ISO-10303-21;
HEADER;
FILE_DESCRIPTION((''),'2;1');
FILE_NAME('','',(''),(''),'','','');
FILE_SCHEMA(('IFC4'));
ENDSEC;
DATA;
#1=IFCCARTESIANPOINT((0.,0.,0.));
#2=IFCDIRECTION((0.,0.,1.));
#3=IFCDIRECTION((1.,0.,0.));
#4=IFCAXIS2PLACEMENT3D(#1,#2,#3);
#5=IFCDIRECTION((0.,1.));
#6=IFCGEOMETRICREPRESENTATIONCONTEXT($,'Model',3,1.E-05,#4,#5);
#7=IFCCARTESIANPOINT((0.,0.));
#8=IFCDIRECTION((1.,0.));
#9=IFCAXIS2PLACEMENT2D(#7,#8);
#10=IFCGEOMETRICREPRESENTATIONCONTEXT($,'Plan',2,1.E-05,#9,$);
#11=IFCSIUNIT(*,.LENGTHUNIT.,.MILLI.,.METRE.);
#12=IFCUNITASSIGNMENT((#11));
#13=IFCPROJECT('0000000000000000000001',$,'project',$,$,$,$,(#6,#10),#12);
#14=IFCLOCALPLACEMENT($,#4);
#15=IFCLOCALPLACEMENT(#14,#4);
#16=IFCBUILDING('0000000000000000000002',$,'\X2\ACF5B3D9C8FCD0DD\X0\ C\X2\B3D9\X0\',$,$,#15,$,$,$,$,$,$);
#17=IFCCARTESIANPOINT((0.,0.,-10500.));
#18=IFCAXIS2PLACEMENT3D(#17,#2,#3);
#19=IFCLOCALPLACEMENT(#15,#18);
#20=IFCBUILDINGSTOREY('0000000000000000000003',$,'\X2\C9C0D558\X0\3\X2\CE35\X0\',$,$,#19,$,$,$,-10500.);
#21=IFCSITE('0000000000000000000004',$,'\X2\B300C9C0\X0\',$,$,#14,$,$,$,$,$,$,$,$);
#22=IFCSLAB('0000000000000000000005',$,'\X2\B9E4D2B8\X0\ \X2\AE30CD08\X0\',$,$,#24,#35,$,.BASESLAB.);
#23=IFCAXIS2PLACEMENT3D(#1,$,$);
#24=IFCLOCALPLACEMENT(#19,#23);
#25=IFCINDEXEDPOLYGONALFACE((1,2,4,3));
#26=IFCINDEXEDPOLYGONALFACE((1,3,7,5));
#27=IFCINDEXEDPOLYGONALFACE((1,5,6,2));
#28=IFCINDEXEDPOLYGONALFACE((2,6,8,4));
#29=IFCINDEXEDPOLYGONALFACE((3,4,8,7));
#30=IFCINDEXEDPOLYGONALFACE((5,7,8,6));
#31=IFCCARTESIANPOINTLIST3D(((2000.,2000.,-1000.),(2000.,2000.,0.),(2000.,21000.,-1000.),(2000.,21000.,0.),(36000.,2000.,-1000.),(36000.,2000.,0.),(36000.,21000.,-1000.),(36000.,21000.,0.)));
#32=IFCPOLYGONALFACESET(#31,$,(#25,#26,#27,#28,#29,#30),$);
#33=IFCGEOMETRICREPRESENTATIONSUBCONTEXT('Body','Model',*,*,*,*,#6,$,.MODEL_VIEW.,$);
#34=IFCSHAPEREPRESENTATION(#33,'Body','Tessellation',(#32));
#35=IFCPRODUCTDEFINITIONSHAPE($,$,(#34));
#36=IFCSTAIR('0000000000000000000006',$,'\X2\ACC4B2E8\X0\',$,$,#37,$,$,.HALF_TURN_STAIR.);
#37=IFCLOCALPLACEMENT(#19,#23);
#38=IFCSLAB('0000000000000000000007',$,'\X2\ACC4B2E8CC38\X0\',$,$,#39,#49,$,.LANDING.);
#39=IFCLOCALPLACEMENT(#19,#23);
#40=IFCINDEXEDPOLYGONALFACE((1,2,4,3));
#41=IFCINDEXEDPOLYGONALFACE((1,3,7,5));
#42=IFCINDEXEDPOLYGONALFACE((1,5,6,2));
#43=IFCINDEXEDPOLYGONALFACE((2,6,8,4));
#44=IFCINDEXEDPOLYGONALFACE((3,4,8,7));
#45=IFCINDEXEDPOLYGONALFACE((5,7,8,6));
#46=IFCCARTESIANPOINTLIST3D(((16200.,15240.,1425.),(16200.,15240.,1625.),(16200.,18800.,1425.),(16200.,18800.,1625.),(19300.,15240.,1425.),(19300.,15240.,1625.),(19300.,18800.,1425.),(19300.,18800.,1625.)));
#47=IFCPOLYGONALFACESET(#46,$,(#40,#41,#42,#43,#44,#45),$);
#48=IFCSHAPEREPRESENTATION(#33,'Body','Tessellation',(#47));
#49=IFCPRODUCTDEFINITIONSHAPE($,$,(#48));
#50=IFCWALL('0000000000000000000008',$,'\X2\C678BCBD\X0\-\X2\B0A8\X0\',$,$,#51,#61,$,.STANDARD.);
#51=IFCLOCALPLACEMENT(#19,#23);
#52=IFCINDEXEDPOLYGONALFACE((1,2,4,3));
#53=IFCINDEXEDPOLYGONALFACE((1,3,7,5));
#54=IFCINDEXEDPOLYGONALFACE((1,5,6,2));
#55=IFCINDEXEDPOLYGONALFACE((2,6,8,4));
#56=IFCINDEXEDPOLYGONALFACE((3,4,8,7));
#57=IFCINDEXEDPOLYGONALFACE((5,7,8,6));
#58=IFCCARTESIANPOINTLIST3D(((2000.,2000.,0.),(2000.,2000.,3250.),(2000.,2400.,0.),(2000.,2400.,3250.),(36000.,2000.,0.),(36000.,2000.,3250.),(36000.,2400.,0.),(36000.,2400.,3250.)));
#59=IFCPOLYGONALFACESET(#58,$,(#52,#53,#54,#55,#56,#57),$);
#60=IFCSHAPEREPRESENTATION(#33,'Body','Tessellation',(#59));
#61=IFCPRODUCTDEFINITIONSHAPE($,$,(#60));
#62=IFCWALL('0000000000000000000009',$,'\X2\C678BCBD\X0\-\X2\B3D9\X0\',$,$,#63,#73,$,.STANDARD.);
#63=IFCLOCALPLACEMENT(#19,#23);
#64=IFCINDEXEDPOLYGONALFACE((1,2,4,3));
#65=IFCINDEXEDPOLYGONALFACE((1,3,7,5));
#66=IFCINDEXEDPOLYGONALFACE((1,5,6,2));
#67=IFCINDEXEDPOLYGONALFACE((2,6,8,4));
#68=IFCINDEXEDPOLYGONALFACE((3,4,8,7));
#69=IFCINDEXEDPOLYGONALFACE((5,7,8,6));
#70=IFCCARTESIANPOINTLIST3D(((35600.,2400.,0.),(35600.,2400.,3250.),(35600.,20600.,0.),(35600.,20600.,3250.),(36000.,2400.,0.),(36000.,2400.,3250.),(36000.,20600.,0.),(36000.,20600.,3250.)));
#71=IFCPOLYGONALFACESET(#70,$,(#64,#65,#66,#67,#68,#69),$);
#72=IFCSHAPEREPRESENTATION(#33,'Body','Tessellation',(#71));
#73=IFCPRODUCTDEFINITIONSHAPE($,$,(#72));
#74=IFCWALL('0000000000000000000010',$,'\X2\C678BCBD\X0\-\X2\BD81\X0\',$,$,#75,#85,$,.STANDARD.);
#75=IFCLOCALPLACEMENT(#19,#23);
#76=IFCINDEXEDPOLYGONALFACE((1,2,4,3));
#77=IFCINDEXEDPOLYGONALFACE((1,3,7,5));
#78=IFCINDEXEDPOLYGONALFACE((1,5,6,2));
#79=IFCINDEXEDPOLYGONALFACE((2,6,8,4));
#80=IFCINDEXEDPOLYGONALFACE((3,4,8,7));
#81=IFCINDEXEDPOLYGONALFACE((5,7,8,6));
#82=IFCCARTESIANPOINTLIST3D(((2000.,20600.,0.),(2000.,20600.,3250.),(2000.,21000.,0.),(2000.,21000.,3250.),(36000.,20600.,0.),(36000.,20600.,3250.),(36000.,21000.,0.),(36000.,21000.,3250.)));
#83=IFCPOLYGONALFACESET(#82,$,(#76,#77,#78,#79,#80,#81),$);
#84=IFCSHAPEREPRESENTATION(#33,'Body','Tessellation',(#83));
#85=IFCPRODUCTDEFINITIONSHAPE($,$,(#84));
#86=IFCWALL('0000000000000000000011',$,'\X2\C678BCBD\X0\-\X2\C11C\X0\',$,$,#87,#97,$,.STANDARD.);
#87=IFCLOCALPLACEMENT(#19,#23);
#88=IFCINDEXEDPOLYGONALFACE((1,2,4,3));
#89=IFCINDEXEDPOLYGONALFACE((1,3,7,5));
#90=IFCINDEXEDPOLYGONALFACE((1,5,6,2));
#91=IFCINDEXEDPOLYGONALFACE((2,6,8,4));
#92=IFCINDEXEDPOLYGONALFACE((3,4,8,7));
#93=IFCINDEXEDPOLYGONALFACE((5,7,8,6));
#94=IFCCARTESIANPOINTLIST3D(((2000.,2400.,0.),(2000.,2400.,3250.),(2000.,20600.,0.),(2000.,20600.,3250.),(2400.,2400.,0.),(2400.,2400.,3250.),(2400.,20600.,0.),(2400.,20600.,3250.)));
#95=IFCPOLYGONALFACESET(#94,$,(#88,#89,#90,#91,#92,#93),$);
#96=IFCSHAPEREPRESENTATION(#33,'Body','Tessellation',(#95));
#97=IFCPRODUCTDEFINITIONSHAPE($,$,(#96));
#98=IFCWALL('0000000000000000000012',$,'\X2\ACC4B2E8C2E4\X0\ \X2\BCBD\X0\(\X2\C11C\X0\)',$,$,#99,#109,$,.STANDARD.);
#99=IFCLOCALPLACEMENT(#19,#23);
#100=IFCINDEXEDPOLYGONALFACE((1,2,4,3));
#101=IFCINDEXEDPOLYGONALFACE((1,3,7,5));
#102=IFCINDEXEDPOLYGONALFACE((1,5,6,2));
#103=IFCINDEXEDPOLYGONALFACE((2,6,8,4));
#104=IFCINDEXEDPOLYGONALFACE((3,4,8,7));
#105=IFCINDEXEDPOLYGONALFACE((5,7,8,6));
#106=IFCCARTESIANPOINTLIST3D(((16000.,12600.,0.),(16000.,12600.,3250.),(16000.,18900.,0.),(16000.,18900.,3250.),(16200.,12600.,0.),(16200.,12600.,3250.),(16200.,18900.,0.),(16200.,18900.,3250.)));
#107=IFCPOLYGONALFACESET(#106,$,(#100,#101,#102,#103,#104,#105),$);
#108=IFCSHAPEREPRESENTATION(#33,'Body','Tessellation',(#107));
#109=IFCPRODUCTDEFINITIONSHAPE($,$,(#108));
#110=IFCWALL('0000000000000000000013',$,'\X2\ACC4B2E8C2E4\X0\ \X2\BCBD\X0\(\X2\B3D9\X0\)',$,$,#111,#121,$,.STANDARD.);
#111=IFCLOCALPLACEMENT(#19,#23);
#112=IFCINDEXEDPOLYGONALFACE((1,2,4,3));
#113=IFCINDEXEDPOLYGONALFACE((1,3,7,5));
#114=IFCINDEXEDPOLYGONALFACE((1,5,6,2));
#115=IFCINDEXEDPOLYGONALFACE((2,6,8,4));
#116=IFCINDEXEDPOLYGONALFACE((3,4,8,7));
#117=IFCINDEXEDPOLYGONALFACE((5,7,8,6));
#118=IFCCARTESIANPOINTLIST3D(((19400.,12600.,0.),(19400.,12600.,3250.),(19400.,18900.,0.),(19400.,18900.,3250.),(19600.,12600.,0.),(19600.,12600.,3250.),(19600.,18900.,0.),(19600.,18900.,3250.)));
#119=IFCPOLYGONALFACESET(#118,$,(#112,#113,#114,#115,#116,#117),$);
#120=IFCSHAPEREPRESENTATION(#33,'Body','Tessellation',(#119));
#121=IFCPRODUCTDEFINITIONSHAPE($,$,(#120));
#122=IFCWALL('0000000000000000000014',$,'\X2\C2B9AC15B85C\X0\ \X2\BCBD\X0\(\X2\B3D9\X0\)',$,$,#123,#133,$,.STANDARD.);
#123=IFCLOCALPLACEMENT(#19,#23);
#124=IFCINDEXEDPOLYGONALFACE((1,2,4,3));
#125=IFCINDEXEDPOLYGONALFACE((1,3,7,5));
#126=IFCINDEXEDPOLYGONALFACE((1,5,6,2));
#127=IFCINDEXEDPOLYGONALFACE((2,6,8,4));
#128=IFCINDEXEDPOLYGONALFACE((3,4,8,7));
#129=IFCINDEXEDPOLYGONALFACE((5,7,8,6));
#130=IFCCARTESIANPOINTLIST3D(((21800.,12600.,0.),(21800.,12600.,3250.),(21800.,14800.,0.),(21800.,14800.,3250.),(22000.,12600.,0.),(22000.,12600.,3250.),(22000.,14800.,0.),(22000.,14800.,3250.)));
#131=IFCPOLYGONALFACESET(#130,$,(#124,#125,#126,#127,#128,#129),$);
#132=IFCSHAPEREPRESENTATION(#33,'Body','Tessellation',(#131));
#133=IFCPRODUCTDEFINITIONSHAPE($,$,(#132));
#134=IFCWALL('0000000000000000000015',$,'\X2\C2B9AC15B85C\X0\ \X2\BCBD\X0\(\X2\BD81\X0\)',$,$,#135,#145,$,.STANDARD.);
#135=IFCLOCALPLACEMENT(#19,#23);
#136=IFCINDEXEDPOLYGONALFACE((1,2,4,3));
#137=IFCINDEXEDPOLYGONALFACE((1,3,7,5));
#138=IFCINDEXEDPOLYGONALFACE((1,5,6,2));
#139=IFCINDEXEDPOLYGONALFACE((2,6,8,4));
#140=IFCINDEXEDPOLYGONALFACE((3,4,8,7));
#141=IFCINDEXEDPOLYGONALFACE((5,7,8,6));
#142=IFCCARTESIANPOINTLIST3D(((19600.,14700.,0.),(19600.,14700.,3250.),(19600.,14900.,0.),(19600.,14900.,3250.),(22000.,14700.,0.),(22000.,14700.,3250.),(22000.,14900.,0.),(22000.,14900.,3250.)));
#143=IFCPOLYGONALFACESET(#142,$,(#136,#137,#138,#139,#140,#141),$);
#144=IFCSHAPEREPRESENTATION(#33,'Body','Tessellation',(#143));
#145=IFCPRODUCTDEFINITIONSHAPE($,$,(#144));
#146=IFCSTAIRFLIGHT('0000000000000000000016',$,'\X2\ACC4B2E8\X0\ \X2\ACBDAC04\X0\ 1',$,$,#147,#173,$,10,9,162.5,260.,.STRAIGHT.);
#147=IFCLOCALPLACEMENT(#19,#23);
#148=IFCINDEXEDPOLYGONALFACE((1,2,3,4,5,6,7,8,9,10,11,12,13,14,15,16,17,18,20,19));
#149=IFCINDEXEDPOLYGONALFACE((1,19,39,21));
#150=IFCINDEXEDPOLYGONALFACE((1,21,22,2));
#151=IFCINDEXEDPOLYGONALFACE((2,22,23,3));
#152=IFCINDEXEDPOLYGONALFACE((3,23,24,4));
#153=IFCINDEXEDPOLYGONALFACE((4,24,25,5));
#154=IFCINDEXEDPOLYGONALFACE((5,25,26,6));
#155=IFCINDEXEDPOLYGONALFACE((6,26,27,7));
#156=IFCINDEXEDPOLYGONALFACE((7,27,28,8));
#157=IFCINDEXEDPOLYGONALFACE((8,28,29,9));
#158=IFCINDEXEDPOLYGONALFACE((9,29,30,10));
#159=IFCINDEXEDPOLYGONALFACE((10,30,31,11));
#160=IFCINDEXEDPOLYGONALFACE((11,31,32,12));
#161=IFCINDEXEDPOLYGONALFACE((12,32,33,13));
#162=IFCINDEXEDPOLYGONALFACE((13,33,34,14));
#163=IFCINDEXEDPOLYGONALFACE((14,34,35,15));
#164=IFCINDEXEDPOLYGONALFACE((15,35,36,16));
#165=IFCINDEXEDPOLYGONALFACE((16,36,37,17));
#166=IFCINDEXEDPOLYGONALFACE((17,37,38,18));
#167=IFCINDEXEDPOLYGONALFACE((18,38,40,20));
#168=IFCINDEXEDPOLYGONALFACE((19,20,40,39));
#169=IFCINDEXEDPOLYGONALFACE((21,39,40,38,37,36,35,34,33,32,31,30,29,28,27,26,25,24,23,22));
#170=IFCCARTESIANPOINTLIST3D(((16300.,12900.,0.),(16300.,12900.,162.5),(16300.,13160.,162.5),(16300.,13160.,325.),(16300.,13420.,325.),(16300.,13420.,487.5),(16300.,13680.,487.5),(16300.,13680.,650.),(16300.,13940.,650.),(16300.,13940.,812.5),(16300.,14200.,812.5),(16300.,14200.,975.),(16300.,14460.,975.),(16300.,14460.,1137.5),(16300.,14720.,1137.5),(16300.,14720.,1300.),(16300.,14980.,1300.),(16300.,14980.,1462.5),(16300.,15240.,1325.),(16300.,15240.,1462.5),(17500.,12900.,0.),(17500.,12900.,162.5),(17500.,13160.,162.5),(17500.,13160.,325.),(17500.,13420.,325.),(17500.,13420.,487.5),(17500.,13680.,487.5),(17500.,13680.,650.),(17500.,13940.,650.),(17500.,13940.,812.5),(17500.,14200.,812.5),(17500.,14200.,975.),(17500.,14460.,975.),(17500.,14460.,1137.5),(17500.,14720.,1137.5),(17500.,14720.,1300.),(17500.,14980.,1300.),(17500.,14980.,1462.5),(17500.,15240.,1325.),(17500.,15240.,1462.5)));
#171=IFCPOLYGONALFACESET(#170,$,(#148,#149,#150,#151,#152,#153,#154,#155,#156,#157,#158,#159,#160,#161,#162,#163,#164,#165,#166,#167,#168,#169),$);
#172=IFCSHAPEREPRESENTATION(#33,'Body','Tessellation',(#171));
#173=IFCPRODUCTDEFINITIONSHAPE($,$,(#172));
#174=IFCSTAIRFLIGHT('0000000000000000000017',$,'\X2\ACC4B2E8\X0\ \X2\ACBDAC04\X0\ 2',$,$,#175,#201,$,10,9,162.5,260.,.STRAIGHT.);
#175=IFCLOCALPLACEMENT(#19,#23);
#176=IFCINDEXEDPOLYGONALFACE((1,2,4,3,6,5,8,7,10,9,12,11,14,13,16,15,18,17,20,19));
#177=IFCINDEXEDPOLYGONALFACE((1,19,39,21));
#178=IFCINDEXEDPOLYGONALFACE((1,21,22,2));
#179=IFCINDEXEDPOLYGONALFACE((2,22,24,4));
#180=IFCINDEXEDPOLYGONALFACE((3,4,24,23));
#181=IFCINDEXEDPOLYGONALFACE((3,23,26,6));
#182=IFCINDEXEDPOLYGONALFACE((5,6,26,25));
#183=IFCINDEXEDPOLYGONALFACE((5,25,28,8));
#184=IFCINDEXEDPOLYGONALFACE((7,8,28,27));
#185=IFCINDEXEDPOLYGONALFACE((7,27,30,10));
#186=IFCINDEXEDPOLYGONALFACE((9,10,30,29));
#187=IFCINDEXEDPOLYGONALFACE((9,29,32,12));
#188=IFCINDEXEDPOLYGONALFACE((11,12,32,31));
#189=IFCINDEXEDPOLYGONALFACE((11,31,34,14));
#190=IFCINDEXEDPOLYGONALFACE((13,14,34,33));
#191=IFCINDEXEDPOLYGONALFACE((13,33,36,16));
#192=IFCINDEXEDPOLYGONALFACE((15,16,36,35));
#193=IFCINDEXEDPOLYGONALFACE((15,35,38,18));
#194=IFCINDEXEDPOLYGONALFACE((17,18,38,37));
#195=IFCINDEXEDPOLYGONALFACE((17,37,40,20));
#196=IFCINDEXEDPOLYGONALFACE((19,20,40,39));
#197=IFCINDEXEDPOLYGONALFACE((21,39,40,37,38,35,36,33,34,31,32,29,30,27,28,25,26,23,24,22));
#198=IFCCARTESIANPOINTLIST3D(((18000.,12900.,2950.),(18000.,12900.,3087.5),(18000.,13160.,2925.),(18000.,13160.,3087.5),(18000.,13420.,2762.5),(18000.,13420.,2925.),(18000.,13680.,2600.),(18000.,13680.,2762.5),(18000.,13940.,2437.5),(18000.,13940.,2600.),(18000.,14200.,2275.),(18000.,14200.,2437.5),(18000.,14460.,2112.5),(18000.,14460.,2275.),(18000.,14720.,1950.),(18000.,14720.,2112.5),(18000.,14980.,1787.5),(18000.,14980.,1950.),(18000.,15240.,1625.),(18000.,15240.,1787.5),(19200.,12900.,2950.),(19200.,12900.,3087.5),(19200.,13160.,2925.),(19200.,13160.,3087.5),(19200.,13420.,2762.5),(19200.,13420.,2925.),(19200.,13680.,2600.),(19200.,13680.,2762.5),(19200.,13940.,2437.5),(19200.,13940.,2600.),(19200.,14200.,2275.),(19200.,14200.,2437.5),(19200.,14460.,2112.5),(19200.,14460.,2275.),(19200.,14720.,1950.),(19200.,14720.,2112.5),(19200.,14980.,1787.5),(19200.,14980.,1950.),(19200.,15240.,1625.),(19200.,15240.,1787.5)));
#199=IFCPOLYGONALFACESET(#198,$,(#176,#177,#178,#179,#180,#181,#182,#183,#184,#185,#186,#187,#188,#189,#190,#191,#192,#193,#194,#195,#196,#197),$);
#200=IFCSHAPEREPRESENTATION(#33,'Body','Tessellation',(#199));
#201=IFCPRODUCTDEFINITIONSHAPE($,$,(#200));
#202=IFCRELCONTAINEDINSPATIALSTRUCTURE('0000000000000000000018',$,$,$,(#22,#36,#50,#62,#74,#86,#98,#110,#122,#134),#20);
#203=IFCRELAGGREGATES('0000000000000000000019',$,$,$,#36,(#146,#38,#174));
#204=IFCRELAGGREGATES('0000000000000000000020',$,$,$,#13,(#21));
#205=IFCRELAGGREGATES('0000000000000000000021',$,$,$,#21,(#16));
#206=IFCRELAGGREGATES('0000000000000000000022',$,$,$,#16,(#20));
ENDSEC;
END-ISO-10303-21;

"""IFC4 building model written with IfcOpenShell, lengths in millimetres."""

from ifc_helpers import new_model, si_unit, direction, frame, origin_with_axes, origin_2d_with_axis, place, context, subcontext, project, spatial, polyline, outline, extrude, element, aggregate, save


model = new_model("IFC4")

# Units and contexts
model_context = context("Model", 3, precision=1e-05, world=origin_with_axes(), true_north=direction((0.0, 1.0)))
plan_context = context("Plan", 2, precision=1e-05, world=origin_2d_with_axis())
body_context = subcontext(model_context, "Body", "Model", "MODEL_VIEW")
ifc_project = project(units=[si_unit("LENGTHUNIT", "METRE", prefix="MILLI")], contexts=[model_context, plan_context])

# Site, building, storey
site_placement = place(None, origin_with_axes())
site = spatial("IfcSite", under=ifc_project, at=site_placement, Name="대지")
building_placement = place(site_placement, origin_with_axes())
building = spatial("IfcBuilding", under=site, at=building_placement, Name="공동주택 C동")
storey_placement = place(building_placement, frame((0.0, 0.0, -10500.0), z_axis=(0.0, 0.0, 1.0), x_axis=(1.0, 0.0, 0.0)))
storey = spatial("IfcBuildingStorey", under=building, at=storey_placement, Name="지하3층", Elevation=-10500.0)

# Slab
slab_1_placement = place(storey_placement, origin_with_axes())
element("IfcSlab", 1, at=slab_1_placement, inside=storey, Name="매트 기초", PredefinedType="BASESLAB", context=body_context, shape_type="SweptSolid", body=[
    extrude(outline(polyline([(2000.0, 2000.0), (36000.0, 2000.0), (36000.0, 21000.0), (2000.0, 21000.0), (2000.0, 2000.0)])), frame((0.0, 0.0, -1000.0), z_axis=(0.0, 0.0, 1.0), x_axis=(1.0, 0.0, 0.0)), (0.0, 0.0, 1.0), 1000.0),
])

# Stair, slab
stair_placement = place(storey_placement, origin_with_axes())
stair = element("IfcStair", 2, at=stair_placement, inside=storey, Name="계단", PredefinedType="HALF_TURN_STAIR")
slab_2_placement = place(stair_placement, origin_with_axes())
slab_2 = element("IfcSlab", 3, at=slab_2_placement, Name="계단참", PredefinedType="LANDING", context=body_context, shape_type="SweptSolid", body=[
    extrude(outline(polyline([(16200.0, 15240.0), (19300.0, 15240.0), (19300.0, 18800.0), (16200.0, 18800.0), (16200.0, 15240.0)])), frame((0.0, 0.0, 1425.0), z_axis=(0.0, 0.0, 1.0), x_axis=(1.0, 0.0, 0.0)), (0.0, 0.0, 1.0), 200.0),
])

# Walls
wall_1_placement = place(storey_placement, origin_with_axes())
element("IfcWall", 4, at=wall_1_placement, inside=storey, Name="외벽-남", PredefinedType="STANDARD", context=body_context, shape_type="SweptSolid", body=[
    extrude(outline(polyline([(2000.0, 2400.0), (36000.0, 2400.0), (36000.0, 2000.0), (2000.0, 2000.0), (2000.0, 2400.0)])), origin_with_axes(), (0.0, 0.0, 1.0), 3250.0),
])
wall_2_placement = place(storey_placement, origin_with_axes())
element("IfcWall", 5, at=wall_2_placement, inside=storey, Name="외벽-동", PredefinedType="STANDARD", context=body_context, shape_type="SweptSolid", body=[
    extrude(outline(polyline([(35600.0, 2400.0), (35600.0, 20600.0), (36000.0, 20600.0), (36000.0, 2400.0), (35600.0, 2400.0)])), origin_with_axes(), (0.0, 0.0, 1.0), 3250.0),
])
wall_3_placement = place(storey_placement, origin_with_axes())
element("IfcWall", 6, at=wall_3_placement, inside=storey, Name="외벽-북", PredefinedType="STANDARD", context=body_context, shape_type="SweptSolid", body=[
    extrude(outline(polyline([(36000.0, 20600.0), (2000.0, 20600.0), (2000.0, 21000.0), (36000.0, 21000.0), (36000.0, 20600.0)])), origin_with_axes(), (0.0, 0.0, 1.0), 3250.0),
])
wall_4_placement = place(storey_placement, origin_with_axes())
element("IfcWall", 7, at=wall_4_placement, inside=storey, Name="외벽-서", PredefinedType="STANDARD", context=body_context, shape_type="SweptSolid", body=[
    extrude(outline(polyline([(2400.0, 20600.0), (2400.0, 2400.0), (2000.0, 2400.0), (2000.0, 20600.0), (2400.0, 20600.0)])), origin_with_axes(), (0.0, 0.0, 1.0), 3250.0),
])
wall_5_placement = place(storey_placement, origin_with_axes())
element("IfcWall", 8, at=wall_5_placement, inside=storey, Name="계단실 벽(서)", PredefinedType="STANDARD", context=body_context, shape_type="SweptSolid", body=[
    extrude(outline(polyline([(16000.0, 12600.0), (16000.0, 18900.0), (16200.0, 18900.0), (16200.0, 12600.0), (16000.0, 12600.0)])), origin_with_axes(), (0.0, 0.0, 1.0), 3250.0),
])
wall_6_placement = place(storey_placement, origin_with_axes())
element("IfcWall", 9, at=wall_6_placement, inside=storey, Name="계단실 벽(동)", PredefinedType="STANDARD", context=body_context, shape_type="SweptSolid", body=[
    extrude(outline(polyline([(19400.0, 12600.0), (19400.0, 18900.0), (19600.0, 18900.0), (19600.0, 12600.0), (19400.0, 12600.0)])), origin_with_axes(), (0.0, 0.0, 1.0), 3250.0),
])
wall_7_placement = place(storey_placement, origin_with_axes())
element("IfcWall", 10, at=wall_7_placement, inside=storey, Name="승강로 벽(동)", PredefinedType="STANDARD", context=body_context, shape_type="SweptSolid", body=[
    extrude(outline(polyline([(21800.0, 12600.0), (21800.0, 14800.0), (22000.0, 14800.0), (22000.0, 12600.0), (21800.0, 12600.0)])), origin_with_axes(), (0.0, 0.0, 1.0), 3250.0),
])
wall_8_placement = place(storey_placement, origin_with_axes())
element("IfcWall", 11, at=wall_8_placement, inside=storey, Name="승강로 벽(북)", PredefinedType="STANDARD", context=body_context, shape_type="SweptSolid", body=[
    extrude(outline(polyline([(19600.0, 14900.0), (22000.0, 14900.0), (22000.0, 14700.0), (19600.0, 14700.0), (19600.0, 14900.0)])), origin_with_axes(), (0.0, 0.0, 1.0), 3250.0),
])

# Stair flights
stair_flight_1_placement = place(stair_placement, origin_with_axes())
stair_flight_1 = element("IfcStairFlight", 12, at=stair_flight_1_placement, Name="계단 경간 1", NumberOfRisers=10, NumberOfTreads=9, PredefinedType="STRAIGHT", RiserHeight=162.5, TreadLength=260.0, context=body_context, shape_type="SweptSolid", body=[
    extrude(outline(polyline([(0.0, 0.0), (0.0, 162.5), (260.0, 162.5), (260.0, 325.0), (520.0, 325.0), (520.0, 487.5), (780.0, 487.5), (780.0, 650.0), (1040.0, 650.0), (1040.0, 812.5), (1300.0, 812.5), (1300.0, 975.0), (1560.0, 975.0), (1560.0, 1137.5), (1820.0, 1137.5), (1820.0, 1300.0), (2080.0, 1300.0), (2080.0, 1462.5), (2340.0, 1462.5), (2340.0, 1625.0), (2340.0, 1325.0), (0.0, 0.0)])), frame((16300.0, 12900.0, 0.0), z_axis=(1.0, 0.0, 0.0), x_axis=(0.0, 1.0, 0.0)), (0.0, 0.0, 1.0), 1200.0),
])
stair_flight_2_placement = place(stair_placement, origin_with_axes())
stair_flight_2 = element("IfcStairFlight", 13, at=stair_flight_2_placement, Name="계단 경간 2", NumberOfRisers=10, NumberOfTreads=9, PredefinedType="STRAIGHT", RiserHeight=162.5, TreadLength=260.0, context=body_context, shape_type="SweptSolid", body=[
    extrude(outline(polyline([(0.0, 0.0), (0.0, 162.5), (260.0, 162.5), (260.0, 325.0), (520.0, 325.0), (520.0, 487.5), (780.0, 487.5), (780.0, 650.0), (1040.0, 650.0), (1040.0, 812.5), (1300.0, 812.5), (1300.0, 975.0), (1560.0, 975.0), (1560.0, 1137.5), (1820.0, 1137.5), (1820.0, 1300.0), (2080.0, 1300.0), (2080.0, 1462.5), (2340.0, 1462.5), (2340.0, 1625.0), (2340.0, 1325.0), (0.0, 0.0)])), frame((19200.0, 15240.0, 1625.0), z_axis=(-1.0, 0.0, 0.0), x_axis=(0.0, -1.0, 0.0)), (0.0, 0.0, 1.0), 1200.0),
])

aggregate(stair, [stair_flight_1, slab_2, stair_flight_2])

save(model, "model.ifc")
